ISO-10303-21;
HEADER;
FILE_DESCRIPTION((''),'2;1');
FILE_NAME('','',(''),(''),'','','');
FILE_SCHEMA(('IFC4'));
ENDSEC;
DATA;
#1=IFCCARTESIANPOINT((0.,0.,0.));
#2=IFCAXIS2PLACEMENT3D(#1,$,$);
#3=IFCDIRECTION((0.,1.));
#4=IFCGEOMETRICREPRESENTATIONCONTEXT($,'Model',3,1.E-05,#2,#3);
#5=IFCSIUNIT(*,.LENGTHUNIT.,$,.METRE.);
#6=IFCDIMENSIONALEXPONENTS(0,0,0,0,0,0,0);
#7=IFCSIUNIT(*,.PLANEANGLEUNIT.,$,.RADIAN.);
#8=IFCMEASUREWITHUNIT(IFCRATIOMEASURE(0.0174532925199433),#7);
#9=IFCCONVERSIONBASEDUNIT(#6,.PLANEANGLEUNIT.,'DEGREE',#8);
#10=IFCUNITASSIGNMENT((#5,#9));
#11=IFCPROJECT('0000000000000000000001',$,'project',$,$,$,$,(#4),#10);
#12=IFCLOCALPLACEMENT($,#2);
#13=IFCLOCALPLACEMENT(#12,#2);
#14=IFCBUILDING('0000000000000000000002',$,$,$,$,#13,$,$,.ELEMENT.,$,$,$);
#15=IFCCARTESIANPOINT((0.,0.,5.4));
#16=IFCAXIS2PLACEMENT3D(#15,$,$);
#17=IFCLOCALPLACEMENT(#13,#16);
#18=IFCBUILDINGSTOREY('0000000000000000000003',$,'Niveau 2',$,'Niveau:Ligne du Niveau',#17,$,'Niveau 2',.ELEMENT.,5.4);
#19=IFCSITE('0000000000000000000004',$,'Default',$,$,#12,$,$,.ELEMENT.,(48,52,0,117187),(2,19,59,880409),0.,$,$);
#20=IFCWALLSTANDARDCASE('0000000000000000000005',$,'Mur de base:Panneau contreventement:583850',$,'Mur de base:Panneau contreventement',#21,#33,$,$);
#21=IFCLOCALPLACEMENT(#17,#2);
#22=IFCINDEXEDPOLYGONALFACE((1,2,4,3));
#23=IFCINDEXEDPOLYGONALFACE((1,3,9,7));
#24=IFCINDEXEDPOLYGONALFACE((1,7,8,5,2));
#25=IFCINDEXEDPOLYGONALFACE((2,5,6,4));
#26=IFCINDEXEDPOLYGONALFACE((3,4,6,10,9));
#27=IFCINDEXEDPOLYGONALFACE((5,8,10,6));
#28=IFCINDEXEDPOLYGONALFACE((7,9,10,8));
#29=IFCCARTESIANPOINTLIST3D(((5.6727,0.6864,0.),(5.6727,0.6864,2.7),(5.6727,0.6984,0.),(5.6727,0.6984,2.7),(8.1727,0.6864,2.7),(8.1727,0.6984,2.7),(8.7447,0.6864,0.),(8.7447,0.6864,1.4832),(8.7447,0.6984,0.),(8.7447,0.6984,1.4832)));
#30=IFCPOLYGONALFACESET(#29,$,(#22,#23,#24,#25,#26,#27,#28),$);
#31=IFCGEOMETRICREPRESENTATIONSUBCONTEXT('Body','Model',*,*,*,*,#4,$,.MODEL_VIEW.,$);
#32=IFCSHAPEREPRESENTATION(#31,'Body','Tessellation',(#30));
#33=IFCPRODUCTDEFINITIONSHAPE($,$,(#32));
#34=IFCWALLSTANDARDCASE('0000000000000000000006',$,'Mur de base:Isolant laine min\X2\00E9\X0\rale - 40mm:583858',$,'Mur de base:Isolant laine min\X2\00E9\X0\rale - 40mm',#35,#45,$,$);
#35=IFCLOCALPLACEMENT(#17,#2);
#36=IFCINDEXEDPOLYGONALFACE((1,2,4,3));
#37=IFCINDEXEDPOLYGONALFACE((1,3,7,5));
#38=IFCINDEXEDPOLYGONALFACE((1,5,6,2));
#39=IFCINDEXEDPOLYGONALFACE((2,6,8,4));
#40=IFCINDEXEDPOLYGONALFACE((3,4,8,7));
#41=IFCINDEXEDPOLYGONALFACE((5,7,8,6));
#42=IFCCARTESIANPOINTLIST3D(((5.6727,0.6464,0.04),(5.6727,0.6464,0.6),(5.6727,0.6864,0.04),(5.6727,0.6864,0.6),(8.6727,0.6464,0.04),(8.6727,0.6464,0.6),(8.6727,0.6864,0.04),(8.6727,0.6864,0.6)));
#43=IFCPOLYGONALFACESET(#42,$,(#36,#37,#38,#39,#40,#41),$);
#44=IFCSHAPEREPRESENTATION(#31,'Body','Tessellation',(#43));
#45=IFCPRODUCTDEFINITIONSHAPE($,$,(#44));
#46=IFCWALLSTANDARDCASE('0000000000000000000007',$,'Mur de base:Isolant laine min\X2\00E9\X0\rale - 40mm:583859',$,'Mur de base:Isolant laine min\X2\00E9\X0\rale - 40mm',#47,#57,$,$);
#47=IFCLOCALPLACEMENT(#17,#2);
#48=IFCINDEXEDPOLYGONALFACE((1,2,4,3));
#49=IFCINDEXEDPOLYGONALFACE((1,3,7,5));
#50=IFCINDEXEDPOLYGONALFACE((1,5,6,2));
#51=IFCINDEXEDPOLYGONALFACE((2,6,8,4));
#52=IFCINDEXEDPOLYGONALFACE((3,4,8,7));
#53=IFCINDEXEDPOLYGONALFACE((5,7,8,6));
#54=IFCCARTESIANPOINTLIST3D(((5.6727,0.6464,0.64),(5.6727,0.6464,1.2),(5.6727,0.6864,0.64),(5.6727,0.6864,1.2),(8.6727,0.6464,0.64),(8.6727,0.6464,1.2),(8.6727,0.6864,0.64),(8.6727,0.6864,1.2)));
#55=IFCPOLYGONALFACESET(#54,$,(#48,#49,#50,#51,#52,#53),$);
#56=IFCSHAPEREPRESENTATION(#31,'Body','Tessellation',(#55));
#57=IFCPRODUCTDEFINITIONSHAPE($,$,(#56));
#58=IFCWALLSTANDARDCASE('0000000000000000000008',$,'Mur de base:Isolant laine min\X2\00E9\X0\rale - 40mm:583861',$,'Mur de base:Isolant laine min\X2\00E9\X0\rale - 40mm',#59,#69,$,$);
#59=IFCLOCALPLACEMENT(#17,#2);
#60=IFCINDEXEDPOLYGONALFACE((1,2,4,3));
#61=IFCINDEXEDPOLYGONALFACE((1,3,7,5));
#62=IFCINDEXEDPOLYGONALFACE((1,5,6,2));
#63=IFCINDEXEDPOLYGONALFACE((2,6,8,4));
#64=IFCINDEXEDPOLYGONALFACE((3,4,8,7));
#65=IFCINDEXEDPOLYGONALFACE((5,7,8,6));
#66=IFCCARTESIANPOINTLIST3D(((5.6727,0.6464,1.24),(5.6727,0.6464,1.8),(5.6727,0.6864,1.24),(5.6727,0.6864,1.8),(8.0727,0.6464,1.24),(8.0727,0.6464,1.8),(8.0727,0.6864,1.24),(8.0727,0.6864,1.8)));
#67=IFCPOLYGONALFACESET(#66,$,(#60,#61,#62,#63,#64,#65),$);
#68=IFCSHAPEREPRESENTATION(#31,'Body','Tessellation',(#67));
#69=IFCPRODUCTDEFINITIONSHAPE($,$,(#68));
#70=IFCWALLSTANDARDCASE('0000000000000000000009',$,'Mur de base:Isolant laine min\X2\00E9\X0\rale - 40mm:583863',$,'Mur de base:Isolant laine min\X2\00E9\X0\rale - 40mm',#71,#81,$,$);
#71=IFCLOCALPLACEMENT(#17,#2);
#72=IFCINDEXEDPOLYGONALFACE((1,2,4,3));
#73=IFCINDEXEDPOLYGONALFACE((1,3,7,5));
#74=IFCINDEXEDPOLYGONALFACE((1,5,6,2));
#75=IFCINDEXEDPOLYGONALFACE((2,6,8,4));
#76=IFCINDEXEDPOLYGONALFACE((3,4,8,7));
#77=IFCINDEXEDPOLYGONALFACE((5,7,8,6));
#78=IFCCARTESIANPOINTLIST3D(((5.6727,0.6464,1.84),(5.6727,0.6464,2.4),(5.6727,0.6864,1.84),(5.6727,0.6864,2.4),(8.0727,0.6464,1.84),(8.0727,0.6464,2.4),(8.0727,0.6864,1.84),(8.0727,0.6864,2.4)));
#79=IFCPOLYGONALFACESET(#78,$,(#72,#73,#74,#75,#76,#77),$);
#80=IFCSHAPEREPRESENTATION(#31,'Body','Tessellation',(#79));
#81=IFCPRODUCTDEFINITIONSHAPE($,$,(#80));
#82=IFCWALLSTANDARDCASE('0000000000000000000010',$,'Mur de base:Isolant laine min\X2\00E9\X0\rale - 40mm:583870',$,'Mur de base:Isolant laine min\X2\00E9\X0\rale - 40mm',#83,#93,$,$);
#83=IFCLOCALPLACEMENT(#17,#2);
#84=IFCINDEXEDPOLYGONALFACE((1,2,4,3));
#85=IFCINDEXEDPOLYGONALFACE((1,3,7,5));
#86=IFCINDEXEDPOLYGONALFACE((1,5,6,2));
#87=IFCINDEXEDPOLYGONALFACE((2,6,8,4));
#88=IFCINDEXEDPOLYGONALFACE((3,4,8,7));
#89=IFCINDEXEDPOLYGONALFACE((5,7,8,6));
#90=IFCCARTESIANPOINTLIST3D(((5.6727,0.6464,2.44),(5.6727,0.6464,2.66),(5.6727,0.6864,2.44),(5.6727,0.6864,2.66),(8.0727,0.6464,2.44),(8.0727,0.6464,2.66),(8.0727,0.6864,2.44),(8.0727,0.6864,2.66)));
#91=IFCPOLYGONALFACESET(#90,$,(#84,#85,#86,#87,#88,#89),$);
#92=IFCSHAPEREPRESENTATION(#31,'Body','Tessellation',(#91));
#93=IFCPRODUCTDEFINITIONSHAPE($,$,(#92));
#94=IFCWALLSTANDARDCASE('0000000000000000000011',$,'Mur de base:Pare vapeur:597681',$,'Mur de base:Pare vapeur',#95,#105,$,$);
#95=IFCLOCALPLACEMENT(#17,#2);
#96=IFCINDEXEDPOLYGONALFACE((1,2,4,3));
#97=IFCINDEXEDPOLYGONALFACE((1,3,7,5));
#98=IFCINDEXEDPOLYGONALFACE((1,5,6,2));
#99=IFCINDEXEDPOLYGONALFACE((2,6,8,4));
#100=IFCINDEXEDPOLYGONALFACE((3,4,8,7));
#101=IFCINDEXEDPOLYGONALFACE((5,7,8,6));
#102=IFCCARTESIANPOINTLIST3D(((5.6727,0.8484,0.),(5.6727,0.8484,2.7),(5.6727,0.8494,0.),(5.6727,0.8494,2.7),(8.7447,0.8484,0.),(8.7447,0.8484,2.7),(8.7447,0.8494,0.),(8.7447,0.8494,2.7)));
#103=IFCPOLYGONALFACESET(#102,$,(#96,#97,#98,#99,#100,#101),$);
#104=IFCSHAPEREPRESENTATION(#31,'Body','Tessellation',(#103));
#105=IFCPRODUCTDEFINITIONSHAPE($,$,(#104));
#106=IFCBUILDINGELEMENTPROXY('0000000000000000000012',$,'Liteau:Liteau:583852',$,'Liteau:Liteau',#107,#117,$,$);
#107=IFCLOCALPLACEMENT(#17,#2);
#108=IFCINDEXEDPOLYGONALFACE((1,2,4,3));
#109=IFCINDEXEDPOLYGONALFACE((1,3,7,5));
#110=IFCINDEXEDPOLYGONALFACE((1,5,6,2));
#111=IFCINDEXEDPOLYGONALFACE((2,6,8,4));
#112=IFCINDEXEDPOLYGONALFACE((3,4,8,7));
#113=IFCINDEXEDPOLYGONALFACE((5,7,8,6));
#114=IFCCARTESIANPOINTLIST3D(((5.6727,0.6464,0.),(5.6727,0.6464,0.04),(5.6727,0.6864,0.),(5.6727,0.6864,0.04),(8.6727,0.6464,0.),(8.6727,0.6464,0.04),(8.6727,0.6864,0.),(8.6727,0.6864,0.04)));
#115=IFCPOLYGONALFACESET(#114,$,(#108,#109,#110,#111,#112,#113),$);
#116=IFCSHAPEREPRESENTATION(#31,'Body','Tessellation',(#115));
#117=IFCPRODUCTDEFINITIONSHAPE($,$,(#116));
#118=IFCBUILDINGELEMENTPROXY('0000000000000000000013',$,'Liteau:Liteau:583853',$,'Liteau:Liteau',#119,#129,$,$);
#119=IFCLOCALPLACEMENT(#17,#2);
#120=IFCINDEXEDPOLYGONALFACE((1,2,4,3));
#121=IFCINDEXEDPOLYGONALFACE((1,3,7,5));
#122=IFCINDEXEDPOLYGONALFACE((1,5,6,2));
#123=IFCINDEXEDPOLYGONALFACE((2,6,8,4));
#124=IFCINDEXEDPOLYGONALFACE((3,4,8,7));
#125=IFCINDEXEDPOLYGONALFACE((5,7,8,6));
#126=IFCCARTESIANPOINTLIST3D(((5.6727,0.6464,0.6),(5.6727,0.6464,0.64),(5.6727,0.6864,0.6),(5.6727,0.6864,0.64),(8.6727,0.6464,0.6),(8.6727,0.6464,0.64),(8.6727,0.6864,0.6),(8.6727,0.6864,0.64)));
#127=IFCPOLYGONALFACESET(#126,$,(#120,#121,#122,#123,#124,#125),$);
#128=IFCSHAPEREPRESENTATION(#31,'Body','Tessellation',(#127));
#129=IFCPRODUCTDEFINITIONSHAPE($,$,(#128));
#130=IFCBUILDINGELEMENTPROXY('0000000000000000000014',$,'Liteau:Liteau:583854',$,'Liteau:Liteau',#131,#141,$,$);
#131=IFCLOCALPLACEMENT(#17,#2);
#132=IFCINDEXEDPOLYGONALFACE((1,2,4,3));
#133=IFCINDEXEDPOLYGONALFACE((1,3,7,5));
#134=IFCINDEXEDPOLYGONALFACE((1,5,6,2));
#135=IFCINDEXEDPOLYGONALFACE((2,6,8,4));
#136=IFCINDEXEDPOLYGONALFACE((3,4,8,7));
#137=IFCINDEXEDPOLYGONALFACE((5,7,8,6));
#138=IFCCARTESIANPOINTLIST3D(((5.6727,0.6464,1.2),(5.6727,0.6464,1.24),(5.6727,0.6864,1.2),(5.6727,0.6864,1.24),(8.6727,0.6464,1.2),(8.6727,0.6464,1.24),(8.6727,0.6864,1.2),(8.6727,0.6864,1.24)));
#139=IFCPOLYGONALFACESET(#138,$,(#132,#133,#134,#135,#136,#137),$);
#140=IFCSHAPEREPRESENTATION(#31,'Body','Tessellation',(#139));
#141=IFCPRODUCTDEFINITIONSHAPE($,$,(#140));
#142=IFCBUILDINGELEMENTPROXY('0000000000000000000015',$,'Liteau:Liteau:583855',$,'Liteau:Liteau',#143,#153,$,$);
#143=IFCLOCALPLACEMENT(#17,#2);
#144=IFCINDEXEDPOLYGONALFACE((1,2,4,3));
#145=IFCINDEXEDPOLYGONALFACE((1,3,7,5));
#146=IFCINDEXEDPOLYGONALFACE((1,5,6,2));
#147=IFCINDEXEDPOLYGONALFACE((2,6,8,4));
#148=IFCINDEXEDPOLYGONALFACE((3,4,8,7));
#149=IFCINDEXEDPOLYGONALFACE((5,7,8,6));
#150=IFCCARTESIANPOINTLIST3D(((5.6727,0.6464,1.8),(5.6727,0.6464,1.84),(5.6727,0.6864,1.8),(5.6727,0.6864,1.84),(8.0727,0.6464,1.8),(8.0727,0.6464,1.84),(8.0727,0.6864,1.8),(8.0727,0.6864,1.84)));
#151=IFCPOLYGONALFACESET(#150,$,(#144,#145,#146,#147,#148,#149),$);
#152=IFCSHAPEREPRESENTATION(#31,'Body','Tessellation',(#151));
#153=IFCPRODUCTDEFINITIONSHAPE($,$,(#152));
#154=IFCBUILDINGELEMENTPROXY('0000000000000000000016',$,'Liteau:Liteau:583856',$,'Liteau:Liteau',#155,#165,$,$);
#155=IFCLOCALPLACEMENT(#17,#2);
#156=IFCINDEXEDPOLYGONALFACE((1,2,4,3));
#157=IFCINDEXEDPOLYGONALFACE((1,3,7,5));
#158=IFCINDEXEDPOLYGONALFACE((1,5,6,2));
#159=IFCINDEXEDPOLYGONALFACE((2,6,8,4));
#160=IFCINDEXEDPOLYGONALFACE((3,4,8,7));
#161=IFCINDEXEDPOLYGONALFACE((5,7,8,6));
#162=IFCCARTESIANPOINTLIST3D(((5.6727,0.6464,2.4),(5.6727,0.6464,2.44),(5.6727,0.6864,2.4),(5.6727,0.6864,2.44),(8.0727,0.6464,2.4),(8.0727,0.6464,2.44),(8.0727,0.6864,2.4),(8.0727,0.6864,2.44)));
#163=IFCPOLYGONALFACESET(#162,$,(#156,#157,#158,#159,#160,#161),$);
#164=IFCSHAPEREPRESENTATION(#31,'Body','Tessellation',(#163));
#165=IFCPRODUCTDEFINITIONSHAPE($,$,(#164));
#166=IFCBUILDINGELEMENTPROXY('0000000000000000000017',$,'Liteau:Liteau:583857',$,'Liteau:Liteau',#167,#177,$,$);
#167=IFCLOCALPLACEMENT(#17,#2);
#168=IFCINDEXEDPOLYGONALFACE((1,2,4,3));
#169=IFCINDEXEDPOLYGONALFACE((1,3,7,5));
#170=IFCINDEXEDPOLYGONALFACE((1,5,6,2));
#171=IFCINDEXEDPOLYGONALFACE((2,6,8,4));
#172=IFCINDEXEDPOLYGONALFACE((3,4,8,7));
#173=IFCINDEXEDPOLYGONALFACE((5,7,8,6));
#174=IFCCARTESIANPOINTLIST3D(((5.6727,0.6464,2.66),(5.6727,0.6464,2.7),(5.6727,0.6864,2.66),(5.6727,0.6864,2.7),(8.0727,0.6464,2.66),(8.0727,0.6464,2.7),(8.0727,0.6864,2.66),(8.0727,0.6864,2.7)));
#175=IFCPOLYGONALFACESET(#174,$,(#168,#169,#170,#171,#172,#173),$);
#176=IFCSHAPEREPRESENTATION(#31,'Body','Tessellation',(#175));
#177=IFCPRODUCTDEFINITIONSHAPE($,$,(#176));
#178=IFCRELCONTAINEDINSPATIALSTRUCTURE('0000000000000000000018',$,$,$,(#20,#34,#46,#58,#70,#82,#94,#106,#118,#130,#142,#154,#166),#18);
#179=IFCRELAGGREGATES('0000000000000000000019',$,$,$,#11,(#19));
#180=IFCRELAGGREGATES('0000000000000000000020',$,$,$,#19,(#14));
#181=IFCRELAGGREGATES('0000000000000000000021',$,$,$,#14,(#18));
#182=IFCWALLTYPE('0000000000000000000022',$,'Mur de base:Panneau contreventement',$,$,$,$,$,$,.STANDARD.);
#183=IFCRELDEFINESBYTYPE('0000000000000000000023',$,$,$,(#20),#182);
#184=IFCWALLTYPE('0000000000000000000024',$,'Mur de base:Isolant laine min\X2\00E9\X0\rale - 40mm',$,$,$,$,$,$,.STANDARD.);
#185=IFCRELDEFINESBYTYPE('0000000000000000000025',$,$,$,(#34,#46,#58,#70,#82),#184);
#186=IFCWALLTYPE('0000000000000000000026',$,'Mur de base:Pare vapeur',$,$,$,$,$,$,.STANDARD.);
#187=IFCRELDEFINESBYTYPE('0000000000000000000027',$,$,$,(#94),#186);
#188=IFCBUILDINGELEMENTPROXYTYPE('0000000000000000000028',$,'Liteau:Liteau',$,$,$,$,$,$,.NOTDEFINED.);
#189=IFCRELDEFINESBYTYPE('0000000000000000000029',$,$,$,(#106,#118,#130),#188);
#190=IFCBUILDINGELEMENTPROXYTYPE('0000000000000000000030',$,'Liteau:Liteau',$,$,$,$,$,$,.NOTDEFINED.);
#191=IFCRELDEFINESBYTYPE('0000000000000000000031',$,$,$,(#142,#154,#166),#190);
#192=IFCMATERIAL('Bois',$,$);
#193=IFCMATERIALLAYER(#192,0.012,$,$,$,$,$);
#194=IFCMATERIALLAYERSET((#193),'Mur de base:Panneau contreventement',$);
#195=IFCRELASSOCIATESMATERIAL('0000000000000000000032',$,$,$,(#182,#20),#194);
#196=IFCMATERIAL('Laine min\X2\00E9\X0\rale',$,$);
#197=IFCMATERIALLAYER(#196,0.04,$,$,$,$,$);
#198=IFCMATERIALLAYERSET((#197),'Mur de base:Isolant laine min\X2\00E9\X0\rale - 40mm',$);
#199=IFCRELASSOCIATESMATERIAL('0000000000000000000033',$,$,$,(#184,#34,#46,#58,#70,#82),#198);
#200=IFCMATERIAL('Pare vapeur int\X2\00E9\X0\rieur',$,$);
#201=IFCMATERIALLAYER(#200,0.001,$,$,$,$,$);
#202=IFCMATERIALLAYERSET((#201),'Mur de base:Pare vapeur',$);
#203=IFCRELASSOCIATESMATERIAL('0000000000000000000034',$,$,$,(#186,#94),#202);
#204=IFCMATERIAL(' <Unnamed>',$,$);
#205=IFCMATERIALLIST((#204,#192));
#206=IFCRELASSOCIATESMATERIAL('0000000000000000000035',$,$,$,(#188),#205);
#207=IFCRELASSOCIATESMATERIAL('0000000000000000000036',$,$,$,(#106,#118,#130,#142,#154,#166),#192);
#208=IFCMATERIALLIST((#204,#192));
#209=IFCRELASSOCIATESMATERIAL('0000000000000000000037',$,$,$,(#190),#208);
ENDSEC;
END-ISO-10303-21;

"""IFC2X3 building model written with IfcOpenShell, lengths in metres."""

from ifc_helpers import new_model, entity, si_unit, converted_unit, direction, frame, frame_2d, origin, origin_2d_with_axis, place, context, subcontext, project, spatial, rectangle, extrude, clip, halfspace, source, transform, mapped, material, material_list, layer, layer_set, layer_usage, type_object, type_shapes, element, save


model = new_model("IFC2X3")

# Units and contexts
model_context = context("Model", 3, precision=1e-05, world=origin(), true_north=direction((0.0, 1.0)))
body_context = subcontext(model_context, "Body", "Model", "MODEL_VIEW")
ifc_project = project(units=[si_unit("LENGTHUNIT", "METRE"), converted_unit("PLANEANGLEUNIT", "DEGREE", entity("IfcRatioMeasure", 0.0174532925199433), si_unit("PLANEANGLEUNIT", "RADIAN"), dimensions=[0, 0, 0, 0, 0, 0, 0])], contexts=[model_context])

# Site, building, storey
site_placement = place(None, origin())
site = spatial("IfcSite", under=ifc_project, at=site_placement, Name="Default", CompositionType="ELEMENT", RefLatitude=(48, 52, 0, 117187), RefLongitude=(2, 19, 59, 880409), RefElevation=0.0)
building_placement = place(site_placement, origin())
building = spatial("IfcBuilding", under=site, at=building_placement, CompositionType="ELEMENT")
storey_placement = place(building_placement, frame((0.0, 0.0, 5.4)))
storey = spatial("IfcBuildingStorey", under=building, at=storey_placement, Name="Niveau 2", ObjectType="Niveau:Ligne du Niveau", LongName="Niveau 2", CompositionType="ELEMENT", Elevation=5.4)

# Shared definitions
ifc_material_1 = material(Name="Bois")

# Walls
ifc_layer_1 = layer(ifc_material_1, 0.012)
ifc_layer_set_1 = layer_set([ifc_layer_1], Name="Mur de base:Panneau contreventement")
ifc_layer_usage_1 = layer_usage(ifc_layer_set_1, "AXIS2", "NEGATIVE", 0.006)
wall_type_1 = type_object("IfcWallType", Name="Mur de base:Panneau contreventement", PredefinedType="STANDARD", material=ifc_layer_set_1)
wall_1_placement = place(storey_placement, frame((5.6727, 0.6924, 0.0)))
element("IfcWallStandardCase", 1, at=wall_1_placement, inside=storey, type_object=wall_type_1, material=ifc_layer_usage_1, Name="Mur de base:Panneau contreventement:583850", ObjectType="Mur de base:Panneau contreventement", context=body_context, shape_type="Clipping", body=[
    clip(extrude(rectangle(XDim=3.072, YDim=0.012, at=frame_2d((1.536, 0.0), x_axis=(-1.0, 0.0))), origin(), (0.0, 0.0, 1.0), 2.7), halfspace(frame((2.5, -0.006, 2.7), z_axis=(0.904996, 0.0, 0.425419), x_axis=(0.0, 1.0, 0.0)), False)),
])
ifc_material_2 = material(Name="Laine minérale")
ifc_layer_2 = layer(ifc_material_2, 0.04)
ifc_layer_set_2 = layer_set([ifc_layer_2], Name="Mur de base:Isolant laine minérale - 40mm")
ifc_layer_usage_2 = layer_usage(ifc_layer_set_2, "AXIS2", "NEGATIVE", 0.02)
wall_type_2 = type_object("IfcWallType", Name="Mur de base:Isolant laine minérale - 40mm", PredefinedType="STANDARD", material=ifc_layer_set_2)
wall_2_placement = place(storey_placement, frame((5.6727, 0.6664, 0.04)))
element("IfcWallStandardCase", 2, at=wall_2_placement, inside=storey, type_object=wall_type_2, material=ifc_layer_usage_2, Name="Mur de base:Isolant laine minérale - 40mm:583858", ObjectType="Mur de base:Isolant laine minérale - 40mm", context=body_context, shape_type="SweptSolid", body=[
    extrude(rectangle(XDim=3.0, YDim=0.04, at=frame_2d((1.5, 0.0), x_axis=(-1.0, 0.0))), origin(), (0.0, 0.0, 1.0), 0.56),
])
ifc_layer_usage_3 = layer_usage(ifc_layer_set_2, "AXIS2", "NEGATIVE", 0.02)
wall_3_placement = place(storey_placement, frame((5.6727, 0.6664, 0.64)))
element("IfcWallStandardCase", 3, at=wall_3_placement, inside=storey, type_object=wall_type_2, material=ifc_layer_usage_3, Name="Mur de base:Isolant laine minérale - 40mm:583859", ObjectType="Mur de base:Isolant laine minérale - 40mm", context=body_context, shape_type="SweptSolid", body=[
    extrude(rectangle(XDim=3.0, YDim=0.04, at=frame_2d((1.5, 0.0), x_axis=(-1.0, 0.0))), origin(), (0.0, 0.0, 1.0), 0.56),
])
ifc_layer_usage_4 = layer_usage(ifc_layer_set_2, "AXIS2", "NEGATIVE", 0.02)
wall_4_placement = place(storey_placement, frame((5.6727, 0.6664, 1.24)))
element("IfcWallStandardCase", 4, at=wall_4_placement, inside=storey, type_object=wall_type_2, material=ifc_layer_usage_4, Name="Mur de base:Isolant laine minérale - 40mm:583861", ObjectType="Mur de base:Isolant laine minérale - 40mm", context=body_context, shape_type="SweptSolid", body=[
    extrude(rectangle(XDim=2.4, YDim=0.04, at=frame_2d((1.2, 0.0), x_axis=(-1.0, 0.0))), origin(), (0.0, 0.0, 1.0), 0.56),
])
ifc_layer_usage_5 = layer_usage(ifc_layer_set_2, "AXIS2", "NEGATIVE", 0.02)
wall_5_placement = place(storey_placement, frame((5.6727, 0.6664, 1.84)))
element("IfcWallStandardCase", 5, at=wall_5_placement, inside=storey, type_object=wall_type_2, material=ifc_layer_usage_5, Name="Mur de base:Isolant laine minérale - 40mm:583863", ObjectType="Mur de base:Isolant laine minérale - 40mm", context=body_context, shape_type="SweptSolid", body=[
    extrude(rectangle(XDim=2.4, YDim=0.04, at=frame_2d((1.2, 0.0), x_axis=(-1.0, 0.0))), origin(), (0.0, 0.0, 1.0), 0.56),
])
ifc_layer_usage_6 = layer_usage(ifc_layer_set_2, "AXIS2", "NEGATIVE", 0.02)
wall_6_placement = place(storey_placement, frame((5.6727, 0.6664, 2.44)))
element("IfcWallStandardCase", 6, at=wall_6_placement, inside=storey, type_object=wall_type_2, material=ifc_layer_usage_6, Name="Mur de base:Isolant laine minérale - 40mm:583870", ObjectType="Mur de base:Isolant laine minérale - 40mm", context=body_context, shape_type="SweptSolid", body=[
    extrude(rectangle(XDim=2.4, YDim=0.04, at=frame_2d((1.2, 0.0), x_axis=(-1.0, 0.0))), origin(), (0.0, 0.0, 1.0), 0.22),
])
ifc_material_3 = material(Name="Pare vapeur intérieur")
ifc_layer_3 = layer(ifc_material_3, 0.001)
ifc_layer_set_3 = layer_set([ifc_layer_3], Name="Mur de base:Pare vapeur")
ifc_layer_usage_7 = layer_usage(ifc_layer_set_3, "AXIS2", "NEGATIVE", 0.0005)
wall_type_3 = type_object("IfcWallType", Name="Mur de base:Pare vapeur", PredefinedType="STANDARD", material=ifc_layer_set_3)
wall_7_placement = place(storey_placement, frame((5.6727, 0.8489, 0.0)))
element("IfcWallStandardCase", 7, at=wall_7_placement, inside=storey, type_object=wall_type_3, material=ifc_layer_usage_7, Name="Mur de base:Pare vapeur:597681", ObjectType="Mur de base:Pare vapeur", context=body_context, shape_type="SweptSolid", body=[
    extrude(rectangle(XDim=3.072, YDim=0.001, at=frame_2d((1.536, 0.0), x_axis=(-1.0, 0.0))), origin(), (0.0, 0.0, 1.0), 2.7),
])

# Building element proxies
ifc_material_4 = material(Name=" <Unnamed>")
ifc_material_list_1 = material_list([ifc_material_4, ifc_material_1])
building_element_proxy_type_1 = type_object("IfcBuildingElementProxyType", Name="Liteau:Liteau", PredefinedType="NOTDEFINED", material=ifc_material_list_1)
shared_shape_1 = source(origin(), body_context, "Body", "SweptSolid", [
    extrude(rectangle(XDim=3.0, YDim=0.04, at=origin_2d_with_axis()), frame((1.5, -0.02, 0.0), z_axis=(0.0, 0.0, 1.0), x_axis=(-1.0, 0.0, 0.0)), (0.0, 0.0, 1.0), 0.04),
])
type_shapes(building_element_proxy_type_1, [shared_shape_1])
for number, where, name in (
    (8, (5.6727, 0.6864, 0.0), "Liteau:Liteau:583852"),
    (9, (5.6727, 0.6864, 0.6), "Liteau:Liteau:583853"),
    (10, (5.6727, 0.6864, 1.2), "Liteau:Liteau:583854"),
):
    element("IfcBuildingElementProxy", number, at=place(storey_placement, frame(where)), inside=storey, type_object=building_element_proxy_type_1, material=ifc_material_1, Name=name, ObjectType="Liteau:Liteau", context=body_context, shape_type="MappedRepresentation", body=[
        mapped(shared_shape_1, transform((0.0, 0.0, 0.0), scale=1.0)),
    ])
ifc_material_list_2 = material_list([ifc_material_4, ifc_material_1])
building_element_proxy_type_2 = type_object("IfcBuildingElementProxyType", Name="Liteau:Liteau", PredefinedType="NOTDEFINED", material=ifc_material_list_2)
shared_shape_2 = source(origin(), body_context, "Body", "SweptSolid", [
    extrude(rectangle(XDim=2.4, YDim=0.04, at=origin_2d_with_axis()), frame((1.2, -0.02, 0.0), z_axis=(0.0, 0.0, 1.0), x_axis=(-1.0, 0.0, 0.0)), (0.0, 0.0, 1.0), 0.04),
])
type_shapes(building_element_proxy_type_2, [shared_shape_2])
for number, where, name in (
    (11, (5.6727, 0.6864, 1.8), "Liteau:Liteau:583855"),
    (12, (5.6727, 0.6864, 2.4), "Liteau:Liteau:583856"),
    (13, (5.6727, 0.6864, 2.66), "Liteau:Liteau:583857"),
):
    element("IfcBuildingElementProxy", number, at=place(storey_placement, frame(where)), inside=storey, type_object=building_element_proxy_type_2, material=ifc_material_1, Name=name, ObjectType="Liteau:Liteau", context=body_context, shape_type="MappedRepresentation", body=[
        mapped(shared_shape_2, transform((0.0, 0.0, 0.0), scale=1.0)),
    ])

save(model, "model.ifc")
